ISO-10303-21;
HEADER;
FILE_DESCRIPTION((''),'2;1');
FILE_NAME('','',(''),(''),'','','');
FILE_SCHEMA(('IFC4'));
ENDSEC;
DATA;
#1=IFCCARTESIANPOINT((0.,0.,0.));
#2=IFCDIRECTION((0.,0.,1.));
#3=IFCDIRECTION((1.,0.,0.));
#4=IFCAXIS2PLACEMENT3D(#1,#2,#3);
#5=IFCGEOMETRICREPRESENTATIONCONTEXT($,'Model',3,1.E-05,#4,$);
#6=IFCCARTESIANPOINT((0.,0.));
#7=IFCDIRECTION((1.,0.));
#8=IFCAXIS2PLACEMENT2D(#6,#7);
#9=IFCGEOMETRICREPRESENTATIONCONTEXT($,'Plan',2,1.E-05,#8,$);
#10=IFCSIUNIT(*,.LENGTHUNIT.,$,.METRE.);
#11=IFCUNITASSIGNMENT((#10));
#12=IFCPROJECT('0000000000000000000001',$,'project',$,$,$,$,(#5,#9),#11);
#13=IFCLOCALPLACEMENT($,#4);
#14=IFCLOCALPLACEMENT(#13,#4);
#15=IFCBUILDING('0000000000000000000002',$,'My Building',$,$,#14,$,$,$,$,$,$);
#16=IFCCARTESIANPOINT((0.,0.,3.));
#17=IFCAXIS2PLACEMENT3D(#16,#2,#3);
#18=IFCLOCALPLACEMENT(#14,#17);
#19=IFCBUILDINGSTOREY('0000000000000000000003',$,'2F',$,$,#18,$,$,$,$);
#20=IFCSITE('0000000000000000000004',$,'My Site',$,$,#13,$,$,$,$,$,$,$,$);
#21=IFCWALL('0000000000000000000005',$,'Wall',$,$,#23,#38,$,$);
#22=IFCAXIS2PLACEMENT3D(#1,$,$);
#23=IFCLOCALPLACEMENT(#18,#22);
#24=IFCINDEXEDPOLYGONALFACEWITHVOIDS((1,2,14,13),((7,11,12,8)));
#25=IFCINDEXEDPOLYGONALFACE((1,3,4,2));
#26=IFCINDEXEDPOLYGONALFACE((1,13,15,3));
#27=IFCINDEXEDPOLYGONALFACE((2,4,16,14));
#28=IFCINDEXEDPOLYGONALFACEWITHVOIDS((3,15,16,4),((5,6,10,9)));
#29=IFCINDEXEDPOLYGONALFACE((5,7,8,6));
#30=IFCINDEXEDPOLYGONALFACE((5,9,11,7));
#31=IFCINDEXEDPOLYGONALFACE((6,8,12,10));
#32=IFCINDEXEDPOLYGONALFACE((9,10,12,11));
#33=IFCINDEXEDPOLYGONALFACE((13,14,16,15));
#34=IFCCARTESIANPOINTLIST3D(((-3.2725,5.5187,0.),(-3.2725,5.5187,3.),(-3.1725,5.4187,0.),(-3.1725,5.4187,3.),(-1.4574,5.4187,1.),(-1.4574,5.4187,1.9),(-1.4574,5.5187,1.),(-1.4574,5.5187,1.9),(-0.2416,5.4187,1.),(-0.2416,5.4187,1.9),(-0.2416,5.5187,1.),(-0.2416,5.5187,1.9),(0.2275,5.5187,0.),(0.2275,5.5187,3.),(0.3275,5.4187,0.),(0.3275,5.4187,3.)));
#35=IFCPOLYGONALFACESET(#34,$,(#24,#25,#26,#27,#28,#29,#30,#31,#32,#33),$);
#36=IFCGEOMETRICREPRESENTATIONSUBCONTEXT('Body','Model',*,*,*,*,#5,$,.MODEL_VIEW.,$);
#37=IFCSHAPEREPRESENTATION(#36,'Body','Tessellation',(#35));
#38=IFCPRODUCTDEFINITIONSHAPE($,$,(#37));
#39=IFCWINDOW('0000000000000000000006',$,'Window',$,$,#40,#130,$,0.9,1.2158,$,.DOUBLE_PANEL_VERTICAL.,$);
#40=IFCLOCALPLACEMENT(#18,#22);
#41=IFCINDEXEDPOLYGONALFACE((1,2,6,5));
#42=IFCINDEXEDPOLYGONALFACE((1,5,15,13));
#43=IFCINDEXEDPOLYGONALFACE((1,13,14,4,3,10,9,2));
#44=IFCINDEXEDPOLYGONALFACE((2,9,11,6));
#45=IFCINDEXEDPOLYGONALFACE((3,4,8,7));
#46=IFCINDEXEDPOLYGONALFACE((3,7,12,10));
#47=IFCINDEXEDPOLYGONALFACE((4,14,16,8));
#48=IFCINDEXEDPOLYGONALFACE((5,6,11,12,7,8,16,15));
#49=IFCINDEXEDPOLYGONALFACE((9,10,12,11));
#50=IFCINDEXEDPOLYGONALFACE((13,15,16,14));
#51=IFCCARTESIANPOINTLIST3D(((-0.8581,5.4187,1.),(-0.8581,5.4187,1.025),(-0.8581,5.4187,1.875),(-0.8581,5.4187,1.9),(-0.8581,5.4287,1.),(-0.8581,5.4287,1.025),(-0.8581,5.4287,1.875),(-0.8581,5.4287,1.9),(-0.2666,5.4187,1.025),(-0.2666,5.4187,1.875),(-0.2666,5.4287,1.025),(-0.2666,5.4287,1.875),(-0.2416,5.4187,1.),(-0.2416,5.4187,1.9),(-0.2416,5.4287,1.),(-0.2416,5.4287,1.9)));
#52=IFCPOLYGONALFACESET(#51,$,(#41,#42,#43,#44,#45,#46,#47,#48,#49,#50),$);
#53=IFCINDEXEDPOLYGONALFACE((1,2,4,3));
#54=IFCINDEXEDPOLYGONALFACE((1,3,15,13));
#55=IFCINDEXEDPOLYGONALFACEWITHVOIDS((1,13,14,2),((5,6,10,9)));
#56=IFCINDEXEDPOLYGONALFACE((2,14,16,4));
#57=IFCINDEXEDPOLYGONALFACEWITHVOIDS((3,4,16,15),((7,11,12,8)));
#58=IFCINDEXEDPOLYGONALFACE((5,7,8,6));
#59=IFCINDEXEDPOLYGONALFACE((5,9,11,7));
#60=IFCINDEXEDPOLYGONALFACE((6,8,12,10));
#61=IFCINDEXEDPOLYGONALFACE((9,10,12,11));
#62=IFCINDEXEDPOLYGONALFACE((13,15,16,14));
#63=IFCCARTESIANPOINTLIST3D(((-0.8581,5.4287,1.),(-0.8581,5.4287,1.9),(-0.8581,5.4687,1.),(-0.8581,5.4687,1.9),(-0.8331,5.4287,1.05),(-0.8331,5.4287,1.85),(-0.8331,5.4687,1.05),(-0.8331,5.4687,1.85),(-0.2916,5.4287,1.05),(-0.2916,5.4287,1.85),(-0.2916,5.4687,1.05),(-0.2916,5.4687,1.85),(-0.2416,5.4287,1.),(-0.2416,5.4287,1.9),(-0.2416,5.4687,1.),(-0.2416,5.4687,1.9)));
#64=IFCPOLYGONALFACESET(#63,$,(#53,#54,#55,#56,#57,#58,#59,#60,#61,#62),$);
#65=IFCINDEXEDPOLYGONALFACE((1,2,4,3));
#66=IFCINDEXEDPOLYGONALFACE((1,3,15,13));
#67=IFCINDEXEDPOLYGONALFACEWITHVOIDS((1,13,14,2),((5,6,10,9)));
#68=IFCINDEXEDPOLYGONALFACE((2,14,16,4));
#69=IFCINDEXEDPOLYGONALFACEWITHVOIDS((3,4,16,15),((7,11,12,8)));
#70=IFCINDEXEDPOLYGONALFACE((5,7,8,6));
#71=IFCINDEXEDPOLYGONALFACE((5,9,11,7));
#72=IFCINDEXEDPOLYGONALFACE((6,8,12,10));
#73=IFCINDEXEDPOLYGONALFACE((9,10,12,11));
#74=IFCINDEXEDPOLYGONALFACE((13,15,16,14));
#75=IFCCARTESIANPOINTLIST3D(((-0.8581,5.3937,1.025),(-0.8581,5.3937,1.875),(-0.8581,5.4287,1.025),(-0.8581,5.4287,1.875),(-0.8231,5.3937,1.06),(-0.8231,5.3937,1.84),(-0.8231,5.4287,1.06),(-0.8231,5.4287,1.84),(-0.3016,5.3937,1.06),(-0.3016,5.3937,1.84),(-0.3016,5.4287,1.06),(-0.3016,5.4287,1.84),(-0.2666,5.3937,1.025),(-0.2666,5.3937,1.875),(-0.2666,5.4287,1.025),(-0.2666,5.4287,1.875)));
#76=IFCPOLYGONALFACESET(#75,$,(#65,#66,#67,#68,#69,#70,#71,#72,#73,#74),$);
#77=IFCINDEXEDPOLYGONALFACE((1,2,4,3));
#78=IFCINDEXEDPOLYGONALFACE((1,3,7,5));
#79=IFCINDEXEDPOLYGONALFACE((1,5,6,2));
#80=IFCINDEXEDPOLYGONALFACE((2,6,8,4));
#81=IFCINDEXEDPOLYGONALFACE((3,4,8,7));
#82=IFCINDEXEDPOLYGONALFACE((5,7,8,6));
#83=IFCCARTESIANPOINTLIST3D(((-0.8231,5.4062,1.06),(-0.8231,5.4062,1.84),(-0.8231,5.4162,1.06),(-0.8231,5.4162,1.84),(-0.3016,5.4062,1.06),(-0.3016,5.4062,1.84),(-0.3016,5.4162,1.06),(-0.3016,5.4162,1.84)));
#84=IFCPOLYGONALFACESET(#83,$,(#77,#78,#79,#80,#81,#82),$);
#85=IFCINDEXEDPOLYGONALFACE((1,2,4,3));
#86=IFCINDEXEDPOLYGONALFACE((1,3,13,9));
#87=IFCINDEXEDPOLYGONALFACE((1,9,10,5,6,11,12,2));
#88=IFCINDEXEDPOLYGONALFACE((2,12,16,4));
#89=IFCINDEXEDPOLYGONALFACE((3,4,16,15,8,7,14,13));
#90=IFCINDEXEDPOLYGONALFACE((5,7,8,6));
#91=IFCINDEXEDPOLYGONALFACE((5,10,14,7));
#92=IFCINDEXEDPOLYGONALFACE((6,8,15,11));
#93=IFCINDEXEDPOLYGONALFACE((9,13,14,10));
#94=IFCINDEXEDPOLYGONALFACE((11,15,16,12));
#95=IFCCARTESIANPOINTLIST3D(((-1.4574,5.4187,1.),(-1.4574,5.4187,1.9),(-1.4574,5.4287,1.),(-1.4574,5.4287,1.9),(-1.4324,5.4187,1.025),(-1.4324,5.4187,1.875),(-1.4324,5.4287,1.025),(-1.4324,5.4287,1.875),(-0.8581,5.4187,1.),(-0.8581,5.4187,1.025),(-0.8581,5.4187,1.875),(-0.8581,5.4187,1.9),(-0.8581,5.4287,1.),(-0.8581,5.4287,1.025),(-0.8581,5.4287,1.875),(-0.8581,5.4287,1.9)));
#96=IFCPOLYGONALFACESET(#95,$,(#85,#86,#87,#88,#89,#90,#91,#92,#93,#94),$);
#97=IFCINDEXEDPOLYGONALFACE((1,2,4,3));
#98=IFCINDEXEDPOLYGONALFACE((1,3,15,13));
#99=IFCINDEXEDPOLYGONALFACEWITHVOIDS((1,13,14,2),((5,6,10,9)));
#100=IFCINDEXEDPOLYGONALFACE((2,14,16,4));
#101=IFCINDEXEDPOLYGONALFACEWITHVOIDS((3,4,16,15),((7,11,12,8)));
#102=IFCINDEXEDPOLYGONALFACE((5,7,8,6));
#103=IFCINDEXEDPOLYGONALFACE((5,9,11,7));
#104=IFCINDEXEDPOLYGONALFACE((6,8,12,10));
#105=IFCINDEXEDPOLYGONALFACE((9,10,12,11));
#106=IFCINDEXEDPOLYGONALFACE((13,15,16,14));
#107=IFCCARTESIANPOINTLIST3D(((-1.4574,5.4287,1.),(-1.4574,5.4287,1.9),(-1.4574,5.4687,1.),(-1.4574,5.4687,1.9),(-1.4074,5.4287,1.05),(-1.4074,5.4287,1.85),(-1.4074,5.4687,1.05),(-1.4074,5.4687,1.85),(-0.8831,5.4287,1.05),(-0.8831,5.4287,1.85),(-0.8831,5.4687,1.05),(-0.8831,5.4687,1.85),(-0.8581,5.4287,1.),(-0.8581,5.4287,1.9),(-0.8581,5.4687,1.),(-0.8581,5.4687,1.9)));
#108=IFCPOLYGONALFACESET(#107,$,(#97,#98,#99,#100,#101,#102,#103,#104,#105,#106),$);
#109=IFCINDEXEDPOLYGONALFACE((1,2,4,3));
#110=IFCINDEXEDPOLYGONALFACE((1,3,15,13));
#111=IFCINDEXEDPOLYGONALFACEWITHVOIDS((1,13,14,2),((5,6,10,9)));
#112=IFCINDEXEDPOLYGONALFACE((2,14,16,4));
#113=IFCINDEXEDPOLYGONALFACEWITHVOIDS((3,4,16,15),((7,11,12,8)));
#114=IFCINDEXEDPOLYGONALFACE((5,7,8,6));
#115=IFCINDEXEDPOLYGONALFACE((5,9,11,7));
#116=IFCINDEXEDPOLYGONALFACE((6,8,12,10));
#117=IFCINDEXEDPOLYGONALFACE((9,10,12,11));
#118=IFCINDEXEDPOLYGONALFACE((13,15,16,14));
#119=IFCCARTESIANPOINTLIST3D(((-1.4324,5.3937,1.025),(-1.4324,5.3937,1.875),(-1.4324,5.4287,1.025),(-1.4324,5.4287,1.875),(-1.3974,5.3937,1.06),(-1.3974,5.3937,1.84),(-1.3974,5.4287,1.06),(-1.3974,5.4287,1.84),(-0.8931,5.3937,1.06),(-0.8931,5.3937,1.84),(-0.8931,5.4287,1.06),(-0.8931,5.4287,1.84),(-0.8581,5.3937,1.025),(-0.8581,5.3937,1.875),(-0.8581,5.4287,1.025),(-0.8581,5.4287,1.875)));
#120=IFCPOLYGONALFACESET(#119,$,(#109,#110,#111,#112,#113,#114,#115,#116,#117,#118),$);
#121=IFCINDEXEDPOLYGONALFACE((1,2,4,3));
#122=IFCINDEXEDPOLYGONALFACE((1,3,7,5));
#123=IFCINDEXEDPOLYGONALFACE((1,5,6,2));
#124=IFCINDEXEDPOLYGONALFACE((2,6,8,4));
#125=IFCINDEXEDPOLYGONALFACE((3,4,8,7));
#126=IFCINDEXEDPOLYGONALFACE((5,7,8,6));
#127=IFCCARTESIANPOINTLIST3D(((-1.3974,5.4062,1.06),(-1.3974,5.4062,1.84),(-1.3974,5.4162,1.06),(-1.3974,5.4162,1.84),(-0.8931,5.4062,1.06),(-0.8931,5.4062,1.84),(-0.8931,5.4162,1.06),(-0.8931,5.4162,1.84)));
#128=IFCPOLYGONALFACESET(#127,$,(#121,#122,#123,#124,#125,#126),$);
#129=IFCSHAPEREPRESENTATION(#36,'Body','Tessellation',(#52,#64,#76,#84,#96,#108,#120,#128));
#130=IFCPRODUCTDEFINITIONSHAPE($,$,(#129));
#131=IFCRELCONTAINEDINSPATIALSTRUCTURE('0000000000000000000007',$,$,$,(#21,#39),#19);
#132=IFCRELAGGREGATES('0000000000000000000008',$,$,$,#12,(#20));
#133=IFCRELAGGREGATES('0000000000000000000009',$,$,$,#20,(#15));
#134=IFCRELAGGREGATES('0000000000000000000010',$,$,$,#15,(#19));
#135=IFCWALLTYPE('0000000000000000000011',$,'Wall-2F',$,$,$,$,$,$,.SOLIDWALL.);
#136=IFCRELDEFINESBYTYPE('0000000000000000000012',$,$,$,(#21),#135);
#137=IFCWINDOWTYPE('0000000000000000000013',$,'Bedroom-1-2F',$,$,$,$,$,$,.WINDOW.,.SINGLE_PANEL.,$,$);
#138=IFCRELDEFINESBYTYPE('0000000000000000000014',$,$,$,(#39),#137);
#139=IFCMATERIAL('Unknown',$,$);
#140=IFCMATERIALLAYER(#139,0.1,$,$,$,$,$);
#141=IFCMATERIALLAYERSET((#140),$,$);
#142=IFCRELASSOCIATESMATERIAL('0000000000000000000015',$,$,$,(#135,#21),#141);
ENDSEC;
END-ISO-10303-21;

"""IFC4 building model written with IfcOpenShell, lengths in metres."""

from ifc_helpers import new_model, entity, si_unit, frame, origin_with_axes, origin_2d_with_axis, place, context, subcontext, project, spatial, line, indexed_curve, outline, extrude, shape, source, transform, mapped, material, layer, layer_set, layer_usage, type_object, type_shapes, element, fill, save


model = new_model("IFC4")

# Units and contexts
model_context = context("Model", 3, precision=1e-05, world=origin_with_axes())
plan_context = context("Plan", 2, precision=1e-05, world=origin_2d_with_axis())
body_context_1 = subcontext(model_context, "Body", "Model", "MODEL_VIEW")
body_context_2 = subcontext(plan_context, "Body", "Plan", "PLAN_VIEW")
ifc_project = project(units=[si_unit("LENGTHUNIT", "METRE")], contexts=[model_context, plan_context])

# Site, building, storey
site_placement = place(None, origin_with_axes())
site = spatial("IfcSite", under=ifc_project, at=site_placement, Name="My Site")
building_placement = place(site_placement, origin_with_axes())
building = spatial("IfcBuilding", under=site, at=building_placement, Name="My Building")
storey_placement = place(building_placement, frame((0.0, 0.0, 3.0), z_axis=(0.0, 0.0, 1.0), x_axis=(1.0, 0.0, 0.0)))
storey = spatial("IfcBuildingStorey", under=building, at=storey_placement, Name="2F")

# Shared definitions
ifc_material_1 = material(Name="Unknown")

# Shared definitions
ifc_layer_1 = layer(ifc_material_1, 0.1)
ifc_layer_set_1 = layer_set([ifc_layer_1])
wall_type = type_object("IfcWallType", Name="Wall-2F", PredefinedType="SOLIDWALL", material=ifc_layer_set_1)

# Wall, opening, window
ifc_layer_usage_1 = layer_usage(ifc_layer_set_1, "AXIS2", "POSITIVE", 0.0)
wall_1_placement = place(storey_placement, frame((0.2275, 5.5187, 0.0), z_axis=(0.0, 0.0, 1.0), x_axis=(-1.0, 0.0, 0.0)))
wall_1 = element("IfcWall", 1, at=wall_1_placement, inside=storey, type_object=wall_type, material=ifc_layer_usage_1, Name="Wall", context=body_context_1, shape_type="SweptSolid", body=[
    extrude(outline(indexed_curve([(0.0, 0.0), (-0.1, 0.1), (3.4, 0.1), (3.5, 0.0)], segments=[line(1, 2, 3, 4, 1)])), origin_with_axes(), (0.0, 0.0, 1.0), 3.0),
])
shared_shape_1 = source(origin_with_axes(), body_context_1, "Body", "SweptSolid", [
    extrude(outline(indexed_curve([(0.0, 0.0), (1.2158, 0.0), (1.2158, 0.9), (0.0, 0.9)], segments=[line(1, 2, 3, 4, 1)])), frame((0.0, -0.6, 0.0), z_axis=(0.0, -1.0, 0.0), x_axis=(1.0, 0.0, 0.0)), (0.0, 0.0, -1.0), 1.2),
])
opening_1_placement = place(wall_1_placement, frame((0.4691, 0.0, 1.0), z_axis=(0.0, 0.0, 1.0), x_axis=(1.0, 0.0, 0.0)))
opening_1 = element("IfcOpeningElement", 2, at=opening_1_placement, cuts=wall_1, PredefinedType="OPENING", context=body_context_1, shape_type="MappedRepresentation", body=[
    mapped(shared_shape_1, transform((0.0, 0.0, 0.0), x_axis=(1.0, 0.0, 0.0), y_axis=(0.0, 1.0, 0.0), z_axis=(0.0, 0.0, 1.0), scale=1.0)),
])
window_type_1 = type_object("IfcWindowType", Name="Bedroom-1-2F", PartitioningType="SINGLE_PANEL", PredefinedType="WINDOW")
shared_shape_2 = source(origin_with_axes(), body_context_1, "Body", "SweptSolid", [
    extrude(outline(indexed_curve([(0.6164, 0.0), (0.0, 0.0), (0.0, 0.9), (0.6164, 0.9), (0.6164, 0.875), (0.025, 0.875), (0.025, 0.025), (0.6164, 0.025)], segments=[line(1, 2, 3, 4, 5, 6, 7, 8, 1)])), frame((0.0, 0.09, 0.0), z_axis=(0.0, -1.0, 0.0), x_axis=(1.0, 0.0, 0.0)), (0.0, 0.0, -1.0), 0.01),
    extrude(outline(indexed_curve([(0.0, 0.0), (0.6164, 0.0), (0.6164, 0.9), (0.0, 0.9)], segments=[line(1, 2, 3, 4, 1)]), holes=[indexed_curve([(0.05, 0.05), (0.5914, 0.05), (0.5914, 0.85), (0.05, 0.85)], segments=[line(1, 2, 3, 4, 1)])]), frame((0.0, 0.05, 0.0), z_axis=(0.0, -1.0, 0.0), x_axis=(1.0, 0.0, 0.0)), (0.0, 0.0, -1.0), 0.04),
    extrude(outline(indexed_curve([(0.0, 0.0), (0.5914, 0.0), (0.5914, 0.85), (0.0, 0.85)], segments=[line(1, 2, 3, 4, 1)]), holes=[indexed_curve([(0.035, 0.035), (0.5564, 0.035), (0.5564, 0.815), (0.035, 0.815)], segments=[line(1, 2, 3, 4, 1)])]), frame((0.025, 0.09, 0.025), z_axis=(0.0, -1.0, 0.0), x_axis=(1.0, 0.0, 0.0)), (0.0, 0.0, -1.0), 0.035),
    extrude(outline(indexed_curve([(0.035, 0.035), (0.5564, 0.035), (0.5564, 0.815), (0.035, 0.815)], segments=[line(1, 2, 3, 4, 1)])), frame((0.025, 0.1025, 0.025), z_axis=(0.0, -1.0, 0.0), x_axis=(1.0, 0.0, 0.0)), (0.0, 0.0, -1.0), 0.01),
    extrude(outline(indexed_curve([(0.0, 0.9), (0.5993, 0.9), (0.5993, 0.0), (0.0, 0.0), (0.0, 0.025), (0.5743, 0.025), (0.5743, 0.875), (0.0, 0.875)], segments=[line(1, 2, 3, 4, 5, 6, 7, 8, 1)])), frame((0.6164, 0.09, 0.0), z_axis=(0.0, -1.0, 0.0), x_axis=(1.0, 0.0, 0.0)), (0.0, 0.0, -1.0), 0.01),
    extrude(outline(indexed_curve([(0.0, 0.0), (0.5993, 0.0), (0.5993, 0.9), (0.0, 0.9)], segments=[line(1, 2, 3, 4, 1)]), holes=[indexed_curve([(0.025, 0.05), (0.5493, 0.05), (0.5493, 0.85), (0.025, 0.85)], segments=[line(1, 2, 3, 4, 1)])]), frame((0.6164, 0.05, 0.0), z_axis=(0.0, -1.0, 0.0), x_axis=(1.0, 0.0, 0.0)), (0.0, 0.0, -1.0), 0.04),
    extrude(outline(indexed_curve([(0.0, 0.0), (0.5743, 0.0), (0.5743, 0.85), (0.0, 0.85)], segments=[line(1, 2, 3, 4, 1)]), holes=[indexed_curve([(0.035, 0.035), (0.5393, 0.035), (0.5393, 0.815), (0.035, 0.815)], segments=[line(1, 2, 3, 4, 1)])]), frame((0.6164, 0.09, 0.025), z_axis=(0.0, -1.0, 0.0), x_axis=(1.0, 0.0, 0.0)), (0.0, 0.0, -1.0), 0.035),
    extrude(outline(indexed_curve([(0.035, 0.035), (0.5393, 0.035), (0.5393, 0.815), (0.035, 0.815)], segments=[line(1, 2, 3, 4, 1)])), frame((0.6164, 0.1025, 0.025), z_axis=(0.0, -1.0, 0.0), x_axis=(1.0, 0.0, 0.0)), (0.0, 0.0, -1.0), 0.01),
])
shared_shape_3 = source(origin_with_axes(), body_context_2, "Body", "Curve2D", [
    entity("IfcIndexedPolyCurve", entity("IfcCartesianPointList2D", [[0.05, 0.05], [0.5914, 0.05]])),
    entity("IfcIndexedPolyCurve", entity("IfcCartesianPointList2D", [[0.0, 0.1], [0.025, 0.1], [0.025, 0.09], [0.05, 0.09], [0.05, 0.05], [0.0, 0.05]]), [entity("IfcLineIndex", [1, 2, 3, 4, 5, 6, 1])]),
    entity("IfcIndexedPolyCurve", entity("IfcCartesianPointList2D", [[0.6164, 0.1], [0.6164, 0.1], [0.6164, 0.09], [0.5914, 0.09], [0.5914, 0.05], [0.6164, 0.05]])),
    entity("IfcIndexedPolyCurve", entity("IfcCartesianPointList2D", [[0.025, 0.09], [0.06, 0.09], [0.06, 0.125], [0.025, 0.125]]), [entity("IfcLineIndex", [1, 2, 3, 4, 1])]),
    entity("IfcIndexedPolyCurve", entity("IfcCartesianPointList2D", [[0.6164, 0.09], [0.5814, 0.09], [0.5814, 0.125], [0.6164, 0.125]]), [entity("IfcLineIndex", [1, 2, 3, 4, 1])]),
    entity("IfcIndexedPolyCurve", entity("IfcCartesianPointList2D", [[0.06, 0.09], [0.5814, 0.09]])),
    entity("IfcIndexedPolyCurve", entity("IfcCartesianPointList2D", [[0.06, 0.125], [0.5814, 0.125]])),
    entity("IfcIndexedPolyCurve", entity("IfcCartesianPointList2D", [[0.06, 0.1075], [0.5814, 0.1075]])),
    entity("IfcIndexedPolyCurve", entity("IfcCartesianPointList2D", [[0.6414, 0.05], [1.1658, 0.05]])),
    entity("IfcIndexedPolyCurve", entity("IfcCartesianPointList2D", [[0.6164, 0.1], [0.6164, 0.1], [0.6164, 0.09], [0.6414, 0.09], [0.6414, 0.05], [0.6164, 0.05]])),
    entity("IfcIndexedPolyCurve", entity("IfcCartesianPointList2D", [[1.2158, 0.1], [1.1908, 0.1], [1.1908, 0.09], [1.1658, 0.09], [1.1658, 0.05], [1.2158, 0.05]]), [entity("IfcLineIndex", [1, 2, 3, 4, 5, 6, 1])]),
    entity("IfcIndexedPolyCurve", entity("IfcCartesianPointList2D", [[0.6164, 0.09], [0.6514, 0.09], [0.6514, 0.125], [0.6164, 0.125]]), [entity("IfcLineIndex", [1, 2, 3, 4, 1])]),
    entity("IfcIndexedPolyCurve", entity("IfcCartesianPointList2D", [[1.1908, 0.09], [1.1558, 0.09], [1.1558, 0.125], [1.1908, 0.125]]), [entity("IfcLineIndex", [1, 2, 3, 4, 1])]),
    entity("IfcIndexedPolyCurve", entity("IfcCartesianPointList2D", [[0.6514, 0.09], [1.1558, 0.09]])),
    entity("IfcIndexedPolyCurve", entity("IfcCartesianPointList2D", [[0.6514, 0.125], [1.1558, 0.125]])),
    entity("IfcIndexedPolyCurve", entity("IfcCartesianPointList2D", [[0.6514, 0.1075], [1.1558, 0.1075]])),
])
type_shapes(window_type_1, [shared_shape_2, shared_shape_3])
window_1_placement = place(opening_1_placement, frame((0.0, 0.0, 0.0), z_axis=(0.0, 0.0, 1.0), x_axis=(1.0, 0.0, 0.0)))
window_1 = element("IfcWindow", 3, at=window_1_placement, inside=storey, type_object=window_type_1, Name="Window", OverallHeight=0.9, OverallWidth=1.2158, PartitioningType="DOUBLE_PANEL_VERTICAL", shapes=[
    shape(body_context_1, "Body", "MappedRepresentation", [mapped(shared_shape_2, transform((0.0, 0.0, 0.0), x_axis=(1.0, 0.0, 0.0), y_axis=(0.0, 1.0, 0.0), z_axis=(0.0, 0.0, 1.0), scale=1.0))]),
    shape(body_context_2, "Body", "MappedRepresentation", [mapped(shared_shape_3, transform((0.0, 0.0, 0.0), x_axis=(1.0, 0.0, 0.0), y_axis=(0.0, 1.0, 0.0), z_axis=(0.0, 0.0, 1.0), scale=1.0))]),
])
fill(opening_1, window_1)

save(model, "model.ifc")
